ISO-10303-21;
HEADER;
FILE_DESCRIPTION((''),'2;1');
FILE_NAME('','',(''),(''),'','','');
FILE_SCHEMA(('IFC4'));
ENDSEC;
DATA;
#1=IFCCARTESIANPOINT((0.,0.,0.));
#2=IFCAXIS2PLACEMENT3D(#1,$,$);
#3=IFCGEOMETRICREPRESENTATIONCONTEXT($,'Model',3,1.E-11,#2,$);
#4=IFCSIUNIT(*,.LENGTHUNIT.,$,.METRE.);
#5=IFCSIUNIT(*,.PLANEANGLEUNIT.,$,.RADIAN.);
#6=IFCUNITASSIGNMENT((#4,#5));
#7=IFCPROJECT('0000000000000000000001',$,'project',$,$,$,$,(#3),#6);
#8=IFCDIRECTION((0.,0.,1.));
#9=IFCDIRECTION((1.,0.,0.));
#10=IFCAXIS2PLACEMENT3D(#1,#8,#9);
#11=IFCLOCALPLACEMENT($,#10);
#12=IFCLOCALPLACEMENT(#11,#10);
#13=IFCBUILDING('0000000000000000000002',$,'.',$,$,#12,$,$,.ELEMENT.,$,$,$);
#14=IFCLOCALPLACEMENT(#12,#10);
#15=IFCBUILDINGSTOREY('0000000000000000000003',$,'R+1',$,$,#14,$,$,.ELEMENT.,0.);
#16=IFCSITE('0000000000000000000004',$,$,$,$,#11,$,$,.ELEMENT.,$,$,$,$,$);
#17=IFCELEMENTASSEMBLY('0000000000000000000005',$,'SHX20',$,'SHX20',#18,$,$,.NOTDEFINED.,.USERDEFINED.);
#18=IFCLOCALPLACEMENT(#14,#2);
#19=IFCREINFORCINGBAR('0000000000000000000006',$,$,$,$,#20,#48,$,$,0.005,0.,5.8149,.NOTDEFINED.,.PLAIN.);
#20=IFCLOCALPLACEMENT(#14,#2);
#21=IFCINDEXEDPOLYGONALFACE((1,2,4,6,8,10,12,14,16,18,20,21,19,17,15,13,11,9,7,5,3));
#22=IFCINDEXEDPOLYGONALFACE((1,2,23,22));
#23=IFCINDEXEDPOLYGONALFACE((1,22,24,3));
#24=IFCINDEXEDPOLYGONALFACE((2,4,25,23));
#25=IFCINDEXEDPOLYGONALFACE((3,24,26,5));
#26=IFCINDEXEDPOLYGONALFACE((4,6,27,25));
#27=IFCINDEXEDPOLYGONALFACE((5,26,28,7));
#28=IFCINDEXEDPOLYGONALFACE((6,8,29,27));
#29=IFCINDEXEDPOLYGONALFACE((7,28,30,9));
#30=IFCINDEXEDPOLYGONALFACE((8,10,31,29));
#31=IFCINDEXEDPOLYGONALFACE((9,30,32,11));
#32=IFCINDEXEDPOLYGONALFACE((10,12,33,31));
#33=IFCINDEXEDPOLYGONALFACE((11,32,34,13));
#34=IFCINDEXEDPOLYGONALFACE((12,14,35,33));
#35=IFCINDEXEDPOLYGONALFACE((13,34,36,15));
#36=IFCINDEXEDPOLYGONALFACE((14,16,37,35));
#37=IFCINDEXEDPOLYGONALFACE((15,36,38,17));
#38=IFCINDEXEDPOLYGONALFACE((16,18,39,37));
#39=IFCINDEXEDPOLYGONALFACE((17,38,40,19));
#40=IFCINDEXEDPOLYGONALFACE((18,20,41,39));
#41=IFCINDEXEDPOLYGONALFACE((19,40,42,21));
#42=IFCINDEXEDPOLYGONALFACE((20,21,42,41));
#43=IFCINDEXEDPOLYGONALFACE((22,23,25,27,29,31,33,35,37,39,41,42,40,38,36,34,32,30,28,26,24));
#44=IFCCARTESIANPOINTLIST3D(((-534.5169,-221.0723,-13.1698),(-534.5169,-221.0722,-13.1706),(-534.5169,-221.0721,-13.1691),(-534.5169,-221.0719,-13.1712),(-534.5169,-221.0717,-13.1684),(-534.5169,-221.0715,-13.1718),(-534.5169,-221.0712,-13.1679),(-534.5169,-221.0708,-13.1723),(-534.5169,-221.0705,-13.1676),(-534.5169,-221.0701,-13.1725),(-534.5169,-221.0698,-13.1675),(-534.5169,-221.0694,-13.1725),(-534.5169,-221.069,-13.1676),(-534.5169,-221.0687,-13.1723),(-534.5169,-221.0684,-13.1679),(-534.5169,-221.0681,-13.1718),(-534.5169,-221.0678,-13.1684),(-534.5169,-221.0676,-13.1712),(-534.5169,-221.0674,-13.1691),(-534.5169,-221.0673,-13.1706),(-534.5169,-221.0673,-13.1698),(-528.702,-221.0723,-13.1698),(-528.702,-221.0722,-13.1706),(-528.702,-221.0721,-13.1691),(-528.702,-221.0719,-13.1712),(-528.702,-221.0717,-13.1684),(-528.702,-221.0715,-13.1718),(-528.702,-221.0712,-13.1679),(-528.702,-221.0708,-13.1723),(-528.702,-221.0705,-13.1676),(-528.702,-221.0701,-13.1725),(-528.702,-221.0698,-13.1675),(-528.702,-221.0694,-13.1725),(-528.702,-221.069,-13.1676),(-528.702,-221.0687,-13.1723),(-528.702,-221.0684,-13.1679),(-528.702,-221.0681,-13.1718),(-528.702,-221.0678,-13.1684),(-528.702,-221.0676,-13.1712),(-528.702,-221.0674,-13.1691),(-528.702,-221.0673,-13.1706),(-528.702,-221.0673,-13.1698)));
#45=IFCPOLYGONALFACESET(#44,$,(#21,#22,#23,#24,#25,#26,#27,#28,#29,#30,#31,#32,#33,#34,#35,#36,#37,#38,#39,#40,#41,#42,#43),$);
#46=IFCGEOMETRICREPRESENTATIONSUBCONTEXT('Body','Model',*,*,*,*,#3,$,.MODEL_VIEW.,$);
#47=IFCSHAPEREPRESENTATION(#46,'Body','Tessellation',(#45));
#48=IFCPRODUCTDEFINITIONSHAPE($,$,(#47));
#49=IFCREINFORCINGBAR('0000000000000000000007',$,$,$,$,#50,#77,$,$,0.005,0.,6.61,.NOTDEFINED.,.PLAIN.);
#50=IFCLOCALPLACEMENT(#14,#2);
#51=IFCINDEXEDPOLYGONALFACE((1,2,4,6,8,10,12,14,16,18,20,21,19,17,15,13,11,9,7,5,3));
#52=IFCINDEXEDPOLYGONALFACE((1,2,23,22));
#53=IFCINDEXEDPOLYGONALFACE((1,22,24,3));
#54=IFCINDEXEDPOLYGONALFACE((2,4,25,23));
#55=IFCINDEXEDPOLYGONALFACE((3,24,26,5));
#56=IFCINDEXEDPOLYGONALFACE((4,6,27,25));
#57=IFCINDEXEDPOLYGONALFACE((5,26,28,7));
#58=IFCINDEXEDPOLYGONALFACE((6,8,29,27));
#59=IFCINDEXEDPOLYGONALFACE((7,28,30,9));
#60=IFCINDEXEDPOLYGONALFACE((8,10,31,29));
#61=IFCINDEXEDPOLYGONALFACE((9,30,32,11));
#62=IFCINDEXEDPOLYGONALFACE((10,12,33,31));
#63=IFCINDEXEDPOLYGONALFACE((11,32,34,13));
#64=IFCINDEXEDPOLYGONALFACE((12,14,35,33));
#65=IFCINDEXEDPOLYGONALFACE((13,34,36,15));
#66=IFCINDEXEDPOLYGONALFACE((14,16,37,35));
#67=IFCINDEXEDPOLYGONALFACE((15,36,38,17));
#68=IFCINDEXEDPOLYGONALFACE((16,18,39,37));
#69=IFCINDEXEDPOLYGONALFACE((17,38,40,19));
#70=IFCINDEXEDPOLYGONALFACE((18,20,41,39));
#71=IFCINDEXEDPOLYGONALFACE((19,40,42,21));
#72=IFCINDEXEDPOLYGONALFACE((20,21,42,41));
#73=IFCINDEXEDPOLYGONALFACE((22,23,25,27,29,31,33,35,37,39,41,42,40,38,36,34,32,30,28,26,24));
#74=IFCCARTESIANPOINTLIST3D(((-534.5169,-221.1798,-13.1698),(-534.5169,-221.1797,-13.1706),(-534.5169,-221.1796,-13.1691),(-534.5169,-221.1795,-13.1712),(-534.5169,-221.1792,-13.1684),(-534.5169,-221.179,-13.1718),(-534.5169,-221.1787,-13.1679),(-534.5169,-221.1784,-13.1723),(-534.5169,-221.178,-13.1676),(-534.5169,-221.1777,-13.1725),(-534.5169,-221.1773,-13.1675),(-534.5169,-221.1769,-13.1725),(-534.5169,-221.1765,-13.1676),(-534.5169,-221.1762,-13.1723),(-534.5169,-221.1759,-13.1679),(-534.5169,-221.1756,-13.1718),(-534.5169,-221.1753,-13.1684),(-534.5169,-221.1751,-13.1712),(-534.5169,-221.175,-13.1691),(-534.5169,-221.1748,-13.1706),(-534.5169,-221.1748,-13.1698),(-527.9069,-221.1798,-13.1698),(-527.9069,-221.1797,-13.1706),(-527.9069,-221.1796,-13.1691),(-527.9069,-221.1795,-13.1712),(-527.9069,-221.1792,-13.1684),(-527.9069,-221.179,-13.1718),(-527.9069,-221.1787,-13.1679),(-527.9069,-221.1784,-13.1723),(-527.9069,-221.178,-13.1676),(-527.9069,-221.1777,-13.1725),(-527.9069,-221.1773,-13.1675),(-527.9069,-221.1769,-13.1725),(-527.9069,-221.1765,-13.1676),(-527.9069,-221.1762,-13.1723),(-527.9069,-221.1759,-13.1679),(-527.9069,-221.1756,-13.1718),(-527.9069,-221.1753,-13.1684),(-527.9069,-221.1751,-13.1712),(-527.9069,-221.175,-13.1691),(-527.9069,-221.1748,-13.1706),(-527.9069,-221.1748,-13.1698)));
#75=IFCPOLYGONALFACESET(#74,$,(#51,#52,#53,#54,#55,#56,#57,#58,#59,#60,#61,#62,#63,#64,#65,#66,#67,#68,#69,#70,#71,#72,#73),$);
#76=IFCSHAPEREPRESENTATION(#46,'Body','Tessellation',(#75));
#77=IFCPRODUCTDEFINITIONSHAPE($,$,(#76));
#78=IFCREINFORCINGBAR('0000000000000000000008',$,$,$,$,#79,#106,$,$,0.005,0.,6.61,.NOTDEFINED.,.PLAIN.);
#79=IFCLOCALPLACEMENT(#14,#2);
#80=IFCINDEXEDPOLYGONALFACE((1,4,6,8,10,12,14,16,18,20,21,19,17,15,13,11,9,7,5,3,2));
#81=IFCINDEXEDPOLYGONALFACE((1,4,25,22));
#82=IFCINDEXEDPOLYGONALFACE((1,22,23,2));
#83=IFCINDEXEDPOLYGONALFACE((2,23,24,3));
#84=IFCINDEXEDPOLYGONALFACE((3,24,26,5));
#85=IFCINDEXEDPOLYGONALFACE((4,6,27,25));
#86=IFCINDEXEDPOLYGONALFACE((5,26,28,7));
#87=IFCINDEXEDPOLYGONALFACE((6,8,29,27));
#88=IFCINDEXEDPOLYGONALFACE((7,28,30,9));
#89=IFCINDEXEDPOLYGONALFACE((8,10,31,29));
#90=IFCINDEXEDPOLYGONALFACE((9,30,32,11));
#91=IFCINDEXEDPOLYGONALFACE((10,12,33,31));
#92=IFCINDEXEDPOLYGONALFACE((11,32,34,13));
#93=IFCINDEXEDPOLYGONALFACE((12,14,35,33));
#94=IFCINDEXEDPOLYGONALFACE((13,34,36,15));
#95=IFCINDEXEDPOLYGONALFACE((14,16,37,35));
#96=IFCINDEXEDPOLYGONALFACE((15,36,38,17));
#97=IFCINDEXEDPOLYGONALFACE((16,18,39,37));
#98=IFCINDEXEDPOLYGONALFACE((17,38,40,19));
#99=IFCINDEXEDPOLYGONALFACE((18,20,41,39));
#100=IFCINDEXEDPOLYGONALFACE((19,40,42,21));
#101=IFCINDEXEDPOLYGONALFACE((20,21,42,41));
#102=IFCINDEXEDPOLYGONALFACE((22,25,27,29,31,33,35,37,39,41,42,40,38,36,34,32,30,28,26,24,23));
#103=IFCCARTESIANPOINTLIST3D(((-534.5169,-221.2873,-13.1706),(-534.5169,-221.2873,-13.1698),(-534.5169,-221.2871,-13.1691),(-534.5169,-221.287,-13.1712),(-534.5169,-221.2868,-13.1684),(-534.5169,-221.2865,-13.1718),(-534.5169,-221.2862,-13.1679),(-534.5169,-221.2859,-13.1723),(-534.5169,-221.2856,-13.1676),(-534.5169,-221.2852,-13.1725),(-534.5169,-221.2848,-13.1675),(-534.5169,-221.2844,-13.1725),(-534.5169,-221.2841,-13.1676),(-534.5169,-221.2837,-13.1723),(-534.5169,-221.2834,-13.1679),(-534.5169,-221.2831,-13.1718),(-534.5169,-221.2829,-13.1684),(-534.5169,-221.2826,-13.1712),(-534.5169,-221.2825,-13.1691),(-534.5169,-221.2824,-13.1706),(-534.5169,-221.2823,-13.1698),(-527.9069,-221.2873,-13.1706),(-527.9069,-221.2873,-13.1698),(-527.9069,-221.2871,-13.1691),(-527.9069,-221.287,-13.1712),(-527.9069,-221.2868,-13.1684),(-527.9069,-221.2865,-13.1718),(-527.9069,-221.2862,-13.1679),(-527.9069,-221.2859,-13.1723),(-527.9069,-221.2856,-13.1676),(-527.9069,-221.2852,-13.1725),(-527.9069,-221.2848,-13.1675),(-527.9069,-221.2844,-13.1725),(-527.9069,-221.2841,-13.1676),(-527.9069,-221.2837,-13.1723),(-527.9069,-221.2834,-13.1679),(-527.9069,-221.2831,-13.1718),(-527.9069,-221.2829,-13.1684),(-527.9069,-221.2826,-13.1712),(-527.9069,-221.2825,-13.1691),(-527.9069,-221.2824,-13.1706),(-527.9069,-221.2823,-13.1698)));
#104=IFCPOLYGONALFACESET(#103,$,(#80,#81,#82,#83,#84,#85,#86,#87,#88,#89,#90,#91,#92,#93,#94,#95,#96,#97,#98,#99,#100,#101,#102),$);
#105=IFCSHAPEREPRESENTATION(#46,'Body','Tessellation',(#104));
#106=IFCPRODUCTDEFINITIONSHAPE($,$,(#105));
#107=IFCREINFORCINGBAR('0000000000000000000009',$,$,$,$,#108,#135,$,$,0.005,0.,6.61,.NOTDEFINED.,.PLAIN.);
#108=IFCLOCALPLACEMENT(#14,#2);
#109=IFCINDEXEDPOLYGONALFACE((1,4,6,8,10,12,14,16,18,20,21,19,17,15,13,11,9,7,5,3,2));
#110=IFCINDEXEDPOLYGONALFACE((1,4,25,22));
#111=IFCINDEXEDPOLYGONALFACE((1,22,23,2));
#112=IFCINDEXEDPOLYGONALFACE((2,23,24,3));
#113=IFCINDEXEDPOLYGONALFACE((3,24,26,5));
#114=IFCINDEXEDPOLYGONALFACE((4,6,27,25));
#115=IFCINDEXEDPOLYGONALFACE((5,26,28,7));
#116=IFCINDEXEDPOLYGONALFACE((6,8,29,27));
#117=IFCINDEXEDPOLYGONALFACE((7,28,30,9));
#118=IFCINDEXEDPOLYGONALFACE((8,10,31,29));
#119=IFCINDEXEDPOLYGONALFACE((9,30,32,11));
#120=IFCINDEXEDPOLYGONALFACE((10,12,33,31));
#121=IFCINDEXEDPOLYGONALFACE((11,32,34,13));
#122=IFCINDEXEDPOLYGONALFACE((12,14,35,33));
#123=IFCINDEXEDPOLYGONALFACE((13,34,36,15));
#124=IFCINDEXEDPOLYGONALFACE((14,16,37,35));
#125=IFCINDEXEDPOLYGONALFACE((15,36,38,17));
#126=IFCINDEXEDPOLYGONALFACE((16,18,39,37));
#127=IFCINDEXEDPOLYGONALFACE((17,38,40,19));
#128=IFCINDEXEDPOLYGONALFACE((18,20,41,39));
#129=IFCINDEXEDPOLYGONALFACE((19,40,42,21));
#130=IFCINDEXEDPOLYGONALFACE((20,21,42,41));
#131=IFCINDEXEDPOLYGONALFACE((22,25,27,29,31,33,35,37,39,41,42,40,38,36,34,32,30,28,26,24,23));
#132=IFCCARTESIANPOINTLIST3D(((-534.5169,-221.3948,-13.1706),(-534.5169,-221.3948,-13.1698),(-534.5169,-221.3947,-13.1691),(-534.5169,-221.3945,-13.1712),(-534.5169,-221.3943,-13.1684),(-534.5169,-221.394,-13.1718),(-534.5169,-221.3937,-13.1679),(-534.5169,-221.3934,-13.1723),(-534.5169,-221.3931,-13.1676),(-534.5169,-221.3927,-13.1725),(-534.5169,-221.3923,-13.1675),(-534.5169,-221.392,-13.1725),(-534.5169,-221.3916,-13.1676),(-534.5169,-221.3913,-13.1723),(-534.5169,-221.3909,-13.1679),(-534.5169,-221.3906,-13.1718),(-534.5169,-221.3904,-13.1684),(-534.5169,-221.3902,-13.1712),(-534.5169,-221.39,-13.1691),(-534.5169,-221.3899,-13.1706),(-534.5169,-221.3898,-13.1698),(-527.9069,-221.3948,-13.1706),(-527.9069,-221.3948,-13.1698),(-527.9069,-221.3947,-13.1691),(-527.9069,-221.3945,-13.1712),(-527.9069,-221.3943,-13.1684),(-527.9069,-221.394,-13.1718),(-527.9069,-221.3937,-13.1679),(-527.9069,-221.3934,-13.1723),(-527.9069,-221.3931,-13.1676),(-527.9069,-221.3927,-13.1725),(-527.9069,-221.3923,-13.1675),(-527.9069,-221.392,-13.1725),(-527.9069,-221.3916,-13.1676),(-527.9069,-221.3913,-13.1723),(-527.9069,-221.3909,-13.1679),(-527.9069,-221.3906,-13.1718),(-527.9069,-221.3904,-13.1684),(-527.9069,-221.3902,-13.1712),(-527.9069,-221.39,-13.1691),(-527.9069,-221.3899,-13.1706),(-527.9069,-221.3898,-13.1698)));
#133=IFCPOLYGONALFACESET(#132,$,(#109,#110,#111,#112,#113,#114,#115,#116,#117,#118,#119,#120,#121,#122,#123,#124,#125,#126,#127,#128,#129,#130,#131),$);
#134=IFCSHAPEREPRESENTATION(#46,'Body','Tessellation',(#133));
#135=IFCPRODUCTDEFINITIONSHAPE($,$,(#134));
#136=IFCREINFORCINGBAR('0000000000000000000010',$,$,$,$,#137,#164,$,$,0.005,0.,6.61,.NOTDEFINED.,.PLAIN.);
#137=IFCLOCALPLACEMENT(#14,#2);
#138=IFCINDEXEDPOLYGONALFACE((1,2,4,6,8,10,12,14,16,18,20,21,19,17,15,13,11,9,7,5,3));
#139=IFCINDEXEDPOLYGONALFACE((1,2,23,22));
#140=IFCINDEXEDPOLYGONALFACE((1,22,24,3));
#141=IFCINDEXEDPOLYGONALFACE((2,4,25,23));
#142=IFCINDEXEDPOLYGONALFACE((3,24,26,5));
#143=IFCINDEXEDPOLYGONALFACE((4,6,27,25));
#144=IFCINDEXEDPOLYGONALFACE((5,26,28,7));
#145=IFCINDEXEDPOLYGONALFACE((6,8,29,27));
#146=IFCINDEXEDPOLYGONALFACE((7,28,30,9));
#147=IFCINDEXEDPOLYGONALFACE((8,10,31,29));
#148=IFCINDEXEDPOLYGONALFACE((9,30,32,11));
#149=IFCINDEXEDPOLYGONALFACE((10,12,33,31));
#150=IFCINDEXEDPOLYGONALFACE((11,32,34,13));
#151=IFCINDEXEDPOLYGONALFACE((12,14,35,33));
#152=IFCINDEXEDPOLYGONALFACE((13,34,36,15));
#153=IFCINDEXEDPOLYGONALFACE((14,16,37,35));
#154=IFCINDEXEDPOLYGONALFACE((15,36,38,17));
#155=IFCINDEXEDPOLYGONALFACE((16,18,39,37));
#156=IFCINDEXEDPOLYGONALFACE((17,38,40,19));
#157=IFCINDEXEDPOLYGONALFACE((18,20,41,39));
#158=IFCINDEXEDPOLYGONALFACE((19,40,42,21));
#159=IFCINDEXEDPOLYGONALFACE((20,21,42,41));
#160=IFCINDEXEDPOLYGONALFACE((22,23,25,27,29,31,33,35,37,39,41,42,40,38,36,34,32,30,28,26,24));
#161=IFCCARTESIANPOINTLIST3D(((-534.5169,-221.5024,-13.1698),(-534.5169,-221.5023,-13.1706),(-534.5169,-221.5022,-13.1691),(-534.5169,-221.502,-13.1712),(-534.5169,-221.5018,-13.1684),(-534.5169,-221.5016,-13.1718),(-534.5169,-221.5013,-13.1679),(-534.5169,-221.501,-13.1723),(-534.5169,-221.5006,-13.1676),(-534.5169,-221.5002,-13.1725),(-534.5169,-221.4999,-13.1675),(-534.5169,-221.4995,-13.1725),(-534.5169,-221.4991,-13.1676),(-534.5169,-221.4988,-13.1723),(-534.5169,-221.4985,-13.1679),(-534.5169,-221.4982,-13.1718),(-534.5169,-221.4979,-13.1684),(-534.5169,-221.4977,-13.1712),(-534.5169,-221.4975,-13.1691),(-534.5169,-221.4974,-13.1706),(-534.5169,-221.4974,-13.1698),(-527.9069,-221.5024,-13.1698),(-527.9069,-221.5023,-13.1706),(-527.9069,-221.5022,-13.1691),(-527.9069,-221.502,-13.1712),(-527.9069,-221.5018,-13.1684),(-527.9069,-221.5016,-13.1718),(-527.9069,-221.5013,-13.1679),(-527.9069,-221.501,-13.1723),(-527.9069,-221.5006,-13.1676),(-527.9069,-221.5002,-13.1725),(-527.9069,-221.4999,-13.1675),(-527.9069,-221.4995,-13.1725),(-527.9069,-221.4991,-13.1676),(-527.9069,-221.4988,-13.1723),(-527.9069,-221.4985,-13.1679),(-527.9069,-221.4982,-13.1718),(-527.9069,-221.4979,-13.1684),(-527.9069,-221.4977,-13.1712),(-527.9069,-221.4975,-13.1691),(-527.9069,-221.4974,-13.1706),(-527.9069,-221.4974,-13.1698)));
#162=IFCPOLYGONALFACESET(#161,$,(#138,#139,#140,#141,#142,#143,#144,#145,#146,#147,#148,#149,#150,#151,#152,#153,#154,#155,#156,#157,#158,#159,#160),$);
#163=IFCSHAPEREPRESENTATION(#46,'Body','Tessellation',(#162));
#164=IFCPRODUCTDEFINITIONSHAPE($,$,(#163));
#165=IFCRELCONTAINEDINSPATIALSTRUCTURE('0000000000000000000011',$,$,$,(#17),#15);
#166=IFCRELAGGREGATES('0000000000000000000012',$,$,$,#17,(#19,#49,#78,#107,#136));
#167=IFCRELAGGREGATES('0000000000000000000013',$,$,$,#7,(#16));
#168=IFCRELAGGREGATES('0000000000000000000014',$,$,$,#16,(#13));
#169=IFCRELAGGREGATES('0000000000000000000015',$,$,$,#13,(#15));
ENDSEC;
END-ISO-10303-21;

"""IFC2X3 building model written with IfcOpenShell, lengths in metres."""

from ifc_helpers import new_model, entity, si_unit, origin, origin_with_axes, place, context, subcontext, project, spatial, shape, element, aggregate, save


model = new_model("IFC2X3")

# Units and contexts
model_context = context("Model", 3, precision=1e-11, world=origin())
body_context = subcontext(model_context, "Body", "Model", "MODEL_VIEW")
ifc_project = project(units=[si_unit("LENGTHUNIT", "METRE"), si_unit("PLANEANGLEUNIT", "RADIAN")], contexts=[model_context])

# Site, building, storey
site_placement = place(None, origin_with_axes())
site = spatial("IfcSite", under=ifc_project, at=site_placement, CompositionType="ELEMENT")
building_placement = place(site_placement, origin_with_axes())
building = spatial("IfcBuilding", under=site, at=building_placement, Name=".", CompositionType="ELEMENT")
storey_placement = place(building_placement, origin_with_axes())
storey = spatial("IfcBuildingStorey", under=building, at=storey_placement, Name="R+1", CompositionType="ELEMENT", Elevation=0.0)

# Element assembly, reinforcing bars
assembly_1_placement = place(storey_placement, origin_with_axes())
assembly_1 = element("IfcElementAssembly", 1, at=assembly_1_placement, inside=storey, Name="SHX20", ObjectType="SHX20", AssemblyPlace="NOTDEFINED", PredefinedType="USERDEFINED")
reinforcing_bar_1_placement = place(assembly_1_placement, origin_with_axes())
reinforcing_bar_1 = element("IfcReinforcingBar", 2, at=reinforcing_bar_1_placement, BarLength=5.8149, BarRole="NOTDEFINED", BarSurface="PLAIN", CrossSectionArea=0.0, NominalDiameter=0.005, shapes=[
    shape(body_context, "Body", "AdvancedSweptSolid", [entity("IfcSweptDiskSolid", entity("IfcPolyline", [entity("IfcCartesianPoint", [528.702, 221.0698, 13.17]), entity("IfcCartesianPoint", [534.5169, 221.0698, 13.17])]), 0.0025, None, 0.0, 5.8149)]),
    shape(body_context, "Body", "AdvancedSweptSolid", [entity("IfcSweptDiskSolid", entity("IfcPolyline", [entity("IfcCartesianPoint", [528.702, 221.0698, 13.17]), entity("IfcCartesianPoint", [534.5169, 221.0698, 13.17])]), 0.0025, None, 0.0, 5.8149)]),
])
reinforcing_bar_2_placement = place(assembly_1_placement, origin_with_axes())
reinforcing_bar_2 = element("IfcReinforcingBar", 3, at=reinforcing_bar_2_placement, BarLength=6.61, BarRole="NOTDEFINED", BarSurface="PLAIN", CrossSectionArea=0.0, NominalDiameter=0.005, shapes=[
    shape(body_context, "Body", "AdvancedSweptSolid", [entity("IfcSweptDiskSolid", entity("IfcPolyline", [entity("IfcCartesianPoint", [527.9069, 221.1773, 13.17]), entity("IfcCartesianPoint", [534.5169, 221.1773, 13.17])]), 0.0025, None, 0.0, 6.61)]),
    shape(body_context, "Body", "AdvancedSweptSolid", [entity("IfcSweptDiskSolid", entity("IfcPolyline", [entity("IfcCartesianPoint", [527.9069, 221.1773, 13.17]), entity("IfcCartesianPoint", [534.5169, 221.1773, 13.17])]), 0.0025, None, 0.0, 6.61)]),
])
reinforcing_bar_3_placement = place(assembly_1_placement, origin_with_axes())
reinforcing_bar_3 = element("IfcReinforcingBar", 4, at=reinforcing_bar_3_placement, BarLength=6.61, BarRole="NOTDEFINED", BarSurface="PLAIN", CrossSectionArea=0.0, NominalDiameter=0.005, shapes=[
    shape(body_context, "Body", "AdvancedSweptSolid", [entity("IfcSweptDiskSolid", entity("IfcPolyline", [entity("IfcCartesianPoint", [527.9069, 221.2848, 13.17]), entity("IfcCartesianPoint", [534.5169, 221.2848, 13.17])]), 0.0025, None, 0.0, 6.61)]),
    shape(body_context, "Body", "AdvancedSweptSolid", [entity("IfcSweptDiskSolid", entity("IfcPolyline", [entity("IfcCartesianPoint", [527.9069, 221.2848, 13.17]), entity("IfcCartesianPoint", [534.5169, 221.2848, 13.17])]), 0.0025, None, 0.0, 6.61)]),
])
reinforcing_bar_4_placement = place(assembly_1_placement, origin_with_axes())
reinforcing_bar_4 = element("IfcReinforcingBar", 5, at=reinforcing_bar_4_placement, BarLength=6.61, BarRole="NOTDEFINED", BarSurface="PLAIN", CrossSectionArea=0.0, NominalDiameter=0.005, shapes=[
    shape(body_context, "Body", "AdvancedSweptSolid", [entity("IfcSweptDiskSolid", entity("IfcPolyline", [entity("IfcCartesianPoint", [527.9069, 221.3923, 13.17]), entity("IfcCartesianPoint", [534.5169, 221.3923, 13.17])]), 0.0025, None, 0.0, 6.61)]),
    shape(body_context, "Body", "AdvancedSweptSolid", [entity("IfcSweptDiskSolid", entity("IfcPolyline", [entity("IfcCartesianPoint", [527.9069, 221.3923, 13.17]), entity("IfcCartesianPoint", [534.5169, 221.3923, 13.17])]), 0.0025, None, 0.0, 6.61)]),
])
reinforcing_bar_5_placement = place(assembly_1_placement, origin_with_axes())
reinforcing_bar_5 = element("IfcReinforcingBar", 6, at=reinforcing_bar_5_placement, BarLength=6.61, BarRole="NOTDEFINED", BarSurface="PLAIN", CrossSectionArea=0.0, NominalDiameter=0.005, shapes=[
    shape(body_context, "Body", "AdvancedSweptSolid", [entity("IfcSweptDiskSolid", entity("IfcPolyline", [entity("IfcCartesianPoint", [527.9069, 221.4999, 13.17]), entity("IfcCartesianPoint", [534.5169, 221.4999, 13.17])]), 0.0025, None, 0.0, 6.61)]),
    shape(body_context, "Body", "AdvancedSweptSolid", [entity("IfcSweptDiskSolid", entity("IfcPolyline", [entity("IfcCartesianPoint", [527.9069, 221.4999, 13.17]), entity("IfcCartesianPoint", [534.5169, 221.4999, 13.17])]), 0.0025, None, 0.0, 6.61)]),
])
aggregate(assembly_1, [reinforcing_bar_1, reinforcing_bar_2, reinforcing_bar_3, reinforcing_bar_4, reinforcing_bar_5])

save(model, "model.ifc")
